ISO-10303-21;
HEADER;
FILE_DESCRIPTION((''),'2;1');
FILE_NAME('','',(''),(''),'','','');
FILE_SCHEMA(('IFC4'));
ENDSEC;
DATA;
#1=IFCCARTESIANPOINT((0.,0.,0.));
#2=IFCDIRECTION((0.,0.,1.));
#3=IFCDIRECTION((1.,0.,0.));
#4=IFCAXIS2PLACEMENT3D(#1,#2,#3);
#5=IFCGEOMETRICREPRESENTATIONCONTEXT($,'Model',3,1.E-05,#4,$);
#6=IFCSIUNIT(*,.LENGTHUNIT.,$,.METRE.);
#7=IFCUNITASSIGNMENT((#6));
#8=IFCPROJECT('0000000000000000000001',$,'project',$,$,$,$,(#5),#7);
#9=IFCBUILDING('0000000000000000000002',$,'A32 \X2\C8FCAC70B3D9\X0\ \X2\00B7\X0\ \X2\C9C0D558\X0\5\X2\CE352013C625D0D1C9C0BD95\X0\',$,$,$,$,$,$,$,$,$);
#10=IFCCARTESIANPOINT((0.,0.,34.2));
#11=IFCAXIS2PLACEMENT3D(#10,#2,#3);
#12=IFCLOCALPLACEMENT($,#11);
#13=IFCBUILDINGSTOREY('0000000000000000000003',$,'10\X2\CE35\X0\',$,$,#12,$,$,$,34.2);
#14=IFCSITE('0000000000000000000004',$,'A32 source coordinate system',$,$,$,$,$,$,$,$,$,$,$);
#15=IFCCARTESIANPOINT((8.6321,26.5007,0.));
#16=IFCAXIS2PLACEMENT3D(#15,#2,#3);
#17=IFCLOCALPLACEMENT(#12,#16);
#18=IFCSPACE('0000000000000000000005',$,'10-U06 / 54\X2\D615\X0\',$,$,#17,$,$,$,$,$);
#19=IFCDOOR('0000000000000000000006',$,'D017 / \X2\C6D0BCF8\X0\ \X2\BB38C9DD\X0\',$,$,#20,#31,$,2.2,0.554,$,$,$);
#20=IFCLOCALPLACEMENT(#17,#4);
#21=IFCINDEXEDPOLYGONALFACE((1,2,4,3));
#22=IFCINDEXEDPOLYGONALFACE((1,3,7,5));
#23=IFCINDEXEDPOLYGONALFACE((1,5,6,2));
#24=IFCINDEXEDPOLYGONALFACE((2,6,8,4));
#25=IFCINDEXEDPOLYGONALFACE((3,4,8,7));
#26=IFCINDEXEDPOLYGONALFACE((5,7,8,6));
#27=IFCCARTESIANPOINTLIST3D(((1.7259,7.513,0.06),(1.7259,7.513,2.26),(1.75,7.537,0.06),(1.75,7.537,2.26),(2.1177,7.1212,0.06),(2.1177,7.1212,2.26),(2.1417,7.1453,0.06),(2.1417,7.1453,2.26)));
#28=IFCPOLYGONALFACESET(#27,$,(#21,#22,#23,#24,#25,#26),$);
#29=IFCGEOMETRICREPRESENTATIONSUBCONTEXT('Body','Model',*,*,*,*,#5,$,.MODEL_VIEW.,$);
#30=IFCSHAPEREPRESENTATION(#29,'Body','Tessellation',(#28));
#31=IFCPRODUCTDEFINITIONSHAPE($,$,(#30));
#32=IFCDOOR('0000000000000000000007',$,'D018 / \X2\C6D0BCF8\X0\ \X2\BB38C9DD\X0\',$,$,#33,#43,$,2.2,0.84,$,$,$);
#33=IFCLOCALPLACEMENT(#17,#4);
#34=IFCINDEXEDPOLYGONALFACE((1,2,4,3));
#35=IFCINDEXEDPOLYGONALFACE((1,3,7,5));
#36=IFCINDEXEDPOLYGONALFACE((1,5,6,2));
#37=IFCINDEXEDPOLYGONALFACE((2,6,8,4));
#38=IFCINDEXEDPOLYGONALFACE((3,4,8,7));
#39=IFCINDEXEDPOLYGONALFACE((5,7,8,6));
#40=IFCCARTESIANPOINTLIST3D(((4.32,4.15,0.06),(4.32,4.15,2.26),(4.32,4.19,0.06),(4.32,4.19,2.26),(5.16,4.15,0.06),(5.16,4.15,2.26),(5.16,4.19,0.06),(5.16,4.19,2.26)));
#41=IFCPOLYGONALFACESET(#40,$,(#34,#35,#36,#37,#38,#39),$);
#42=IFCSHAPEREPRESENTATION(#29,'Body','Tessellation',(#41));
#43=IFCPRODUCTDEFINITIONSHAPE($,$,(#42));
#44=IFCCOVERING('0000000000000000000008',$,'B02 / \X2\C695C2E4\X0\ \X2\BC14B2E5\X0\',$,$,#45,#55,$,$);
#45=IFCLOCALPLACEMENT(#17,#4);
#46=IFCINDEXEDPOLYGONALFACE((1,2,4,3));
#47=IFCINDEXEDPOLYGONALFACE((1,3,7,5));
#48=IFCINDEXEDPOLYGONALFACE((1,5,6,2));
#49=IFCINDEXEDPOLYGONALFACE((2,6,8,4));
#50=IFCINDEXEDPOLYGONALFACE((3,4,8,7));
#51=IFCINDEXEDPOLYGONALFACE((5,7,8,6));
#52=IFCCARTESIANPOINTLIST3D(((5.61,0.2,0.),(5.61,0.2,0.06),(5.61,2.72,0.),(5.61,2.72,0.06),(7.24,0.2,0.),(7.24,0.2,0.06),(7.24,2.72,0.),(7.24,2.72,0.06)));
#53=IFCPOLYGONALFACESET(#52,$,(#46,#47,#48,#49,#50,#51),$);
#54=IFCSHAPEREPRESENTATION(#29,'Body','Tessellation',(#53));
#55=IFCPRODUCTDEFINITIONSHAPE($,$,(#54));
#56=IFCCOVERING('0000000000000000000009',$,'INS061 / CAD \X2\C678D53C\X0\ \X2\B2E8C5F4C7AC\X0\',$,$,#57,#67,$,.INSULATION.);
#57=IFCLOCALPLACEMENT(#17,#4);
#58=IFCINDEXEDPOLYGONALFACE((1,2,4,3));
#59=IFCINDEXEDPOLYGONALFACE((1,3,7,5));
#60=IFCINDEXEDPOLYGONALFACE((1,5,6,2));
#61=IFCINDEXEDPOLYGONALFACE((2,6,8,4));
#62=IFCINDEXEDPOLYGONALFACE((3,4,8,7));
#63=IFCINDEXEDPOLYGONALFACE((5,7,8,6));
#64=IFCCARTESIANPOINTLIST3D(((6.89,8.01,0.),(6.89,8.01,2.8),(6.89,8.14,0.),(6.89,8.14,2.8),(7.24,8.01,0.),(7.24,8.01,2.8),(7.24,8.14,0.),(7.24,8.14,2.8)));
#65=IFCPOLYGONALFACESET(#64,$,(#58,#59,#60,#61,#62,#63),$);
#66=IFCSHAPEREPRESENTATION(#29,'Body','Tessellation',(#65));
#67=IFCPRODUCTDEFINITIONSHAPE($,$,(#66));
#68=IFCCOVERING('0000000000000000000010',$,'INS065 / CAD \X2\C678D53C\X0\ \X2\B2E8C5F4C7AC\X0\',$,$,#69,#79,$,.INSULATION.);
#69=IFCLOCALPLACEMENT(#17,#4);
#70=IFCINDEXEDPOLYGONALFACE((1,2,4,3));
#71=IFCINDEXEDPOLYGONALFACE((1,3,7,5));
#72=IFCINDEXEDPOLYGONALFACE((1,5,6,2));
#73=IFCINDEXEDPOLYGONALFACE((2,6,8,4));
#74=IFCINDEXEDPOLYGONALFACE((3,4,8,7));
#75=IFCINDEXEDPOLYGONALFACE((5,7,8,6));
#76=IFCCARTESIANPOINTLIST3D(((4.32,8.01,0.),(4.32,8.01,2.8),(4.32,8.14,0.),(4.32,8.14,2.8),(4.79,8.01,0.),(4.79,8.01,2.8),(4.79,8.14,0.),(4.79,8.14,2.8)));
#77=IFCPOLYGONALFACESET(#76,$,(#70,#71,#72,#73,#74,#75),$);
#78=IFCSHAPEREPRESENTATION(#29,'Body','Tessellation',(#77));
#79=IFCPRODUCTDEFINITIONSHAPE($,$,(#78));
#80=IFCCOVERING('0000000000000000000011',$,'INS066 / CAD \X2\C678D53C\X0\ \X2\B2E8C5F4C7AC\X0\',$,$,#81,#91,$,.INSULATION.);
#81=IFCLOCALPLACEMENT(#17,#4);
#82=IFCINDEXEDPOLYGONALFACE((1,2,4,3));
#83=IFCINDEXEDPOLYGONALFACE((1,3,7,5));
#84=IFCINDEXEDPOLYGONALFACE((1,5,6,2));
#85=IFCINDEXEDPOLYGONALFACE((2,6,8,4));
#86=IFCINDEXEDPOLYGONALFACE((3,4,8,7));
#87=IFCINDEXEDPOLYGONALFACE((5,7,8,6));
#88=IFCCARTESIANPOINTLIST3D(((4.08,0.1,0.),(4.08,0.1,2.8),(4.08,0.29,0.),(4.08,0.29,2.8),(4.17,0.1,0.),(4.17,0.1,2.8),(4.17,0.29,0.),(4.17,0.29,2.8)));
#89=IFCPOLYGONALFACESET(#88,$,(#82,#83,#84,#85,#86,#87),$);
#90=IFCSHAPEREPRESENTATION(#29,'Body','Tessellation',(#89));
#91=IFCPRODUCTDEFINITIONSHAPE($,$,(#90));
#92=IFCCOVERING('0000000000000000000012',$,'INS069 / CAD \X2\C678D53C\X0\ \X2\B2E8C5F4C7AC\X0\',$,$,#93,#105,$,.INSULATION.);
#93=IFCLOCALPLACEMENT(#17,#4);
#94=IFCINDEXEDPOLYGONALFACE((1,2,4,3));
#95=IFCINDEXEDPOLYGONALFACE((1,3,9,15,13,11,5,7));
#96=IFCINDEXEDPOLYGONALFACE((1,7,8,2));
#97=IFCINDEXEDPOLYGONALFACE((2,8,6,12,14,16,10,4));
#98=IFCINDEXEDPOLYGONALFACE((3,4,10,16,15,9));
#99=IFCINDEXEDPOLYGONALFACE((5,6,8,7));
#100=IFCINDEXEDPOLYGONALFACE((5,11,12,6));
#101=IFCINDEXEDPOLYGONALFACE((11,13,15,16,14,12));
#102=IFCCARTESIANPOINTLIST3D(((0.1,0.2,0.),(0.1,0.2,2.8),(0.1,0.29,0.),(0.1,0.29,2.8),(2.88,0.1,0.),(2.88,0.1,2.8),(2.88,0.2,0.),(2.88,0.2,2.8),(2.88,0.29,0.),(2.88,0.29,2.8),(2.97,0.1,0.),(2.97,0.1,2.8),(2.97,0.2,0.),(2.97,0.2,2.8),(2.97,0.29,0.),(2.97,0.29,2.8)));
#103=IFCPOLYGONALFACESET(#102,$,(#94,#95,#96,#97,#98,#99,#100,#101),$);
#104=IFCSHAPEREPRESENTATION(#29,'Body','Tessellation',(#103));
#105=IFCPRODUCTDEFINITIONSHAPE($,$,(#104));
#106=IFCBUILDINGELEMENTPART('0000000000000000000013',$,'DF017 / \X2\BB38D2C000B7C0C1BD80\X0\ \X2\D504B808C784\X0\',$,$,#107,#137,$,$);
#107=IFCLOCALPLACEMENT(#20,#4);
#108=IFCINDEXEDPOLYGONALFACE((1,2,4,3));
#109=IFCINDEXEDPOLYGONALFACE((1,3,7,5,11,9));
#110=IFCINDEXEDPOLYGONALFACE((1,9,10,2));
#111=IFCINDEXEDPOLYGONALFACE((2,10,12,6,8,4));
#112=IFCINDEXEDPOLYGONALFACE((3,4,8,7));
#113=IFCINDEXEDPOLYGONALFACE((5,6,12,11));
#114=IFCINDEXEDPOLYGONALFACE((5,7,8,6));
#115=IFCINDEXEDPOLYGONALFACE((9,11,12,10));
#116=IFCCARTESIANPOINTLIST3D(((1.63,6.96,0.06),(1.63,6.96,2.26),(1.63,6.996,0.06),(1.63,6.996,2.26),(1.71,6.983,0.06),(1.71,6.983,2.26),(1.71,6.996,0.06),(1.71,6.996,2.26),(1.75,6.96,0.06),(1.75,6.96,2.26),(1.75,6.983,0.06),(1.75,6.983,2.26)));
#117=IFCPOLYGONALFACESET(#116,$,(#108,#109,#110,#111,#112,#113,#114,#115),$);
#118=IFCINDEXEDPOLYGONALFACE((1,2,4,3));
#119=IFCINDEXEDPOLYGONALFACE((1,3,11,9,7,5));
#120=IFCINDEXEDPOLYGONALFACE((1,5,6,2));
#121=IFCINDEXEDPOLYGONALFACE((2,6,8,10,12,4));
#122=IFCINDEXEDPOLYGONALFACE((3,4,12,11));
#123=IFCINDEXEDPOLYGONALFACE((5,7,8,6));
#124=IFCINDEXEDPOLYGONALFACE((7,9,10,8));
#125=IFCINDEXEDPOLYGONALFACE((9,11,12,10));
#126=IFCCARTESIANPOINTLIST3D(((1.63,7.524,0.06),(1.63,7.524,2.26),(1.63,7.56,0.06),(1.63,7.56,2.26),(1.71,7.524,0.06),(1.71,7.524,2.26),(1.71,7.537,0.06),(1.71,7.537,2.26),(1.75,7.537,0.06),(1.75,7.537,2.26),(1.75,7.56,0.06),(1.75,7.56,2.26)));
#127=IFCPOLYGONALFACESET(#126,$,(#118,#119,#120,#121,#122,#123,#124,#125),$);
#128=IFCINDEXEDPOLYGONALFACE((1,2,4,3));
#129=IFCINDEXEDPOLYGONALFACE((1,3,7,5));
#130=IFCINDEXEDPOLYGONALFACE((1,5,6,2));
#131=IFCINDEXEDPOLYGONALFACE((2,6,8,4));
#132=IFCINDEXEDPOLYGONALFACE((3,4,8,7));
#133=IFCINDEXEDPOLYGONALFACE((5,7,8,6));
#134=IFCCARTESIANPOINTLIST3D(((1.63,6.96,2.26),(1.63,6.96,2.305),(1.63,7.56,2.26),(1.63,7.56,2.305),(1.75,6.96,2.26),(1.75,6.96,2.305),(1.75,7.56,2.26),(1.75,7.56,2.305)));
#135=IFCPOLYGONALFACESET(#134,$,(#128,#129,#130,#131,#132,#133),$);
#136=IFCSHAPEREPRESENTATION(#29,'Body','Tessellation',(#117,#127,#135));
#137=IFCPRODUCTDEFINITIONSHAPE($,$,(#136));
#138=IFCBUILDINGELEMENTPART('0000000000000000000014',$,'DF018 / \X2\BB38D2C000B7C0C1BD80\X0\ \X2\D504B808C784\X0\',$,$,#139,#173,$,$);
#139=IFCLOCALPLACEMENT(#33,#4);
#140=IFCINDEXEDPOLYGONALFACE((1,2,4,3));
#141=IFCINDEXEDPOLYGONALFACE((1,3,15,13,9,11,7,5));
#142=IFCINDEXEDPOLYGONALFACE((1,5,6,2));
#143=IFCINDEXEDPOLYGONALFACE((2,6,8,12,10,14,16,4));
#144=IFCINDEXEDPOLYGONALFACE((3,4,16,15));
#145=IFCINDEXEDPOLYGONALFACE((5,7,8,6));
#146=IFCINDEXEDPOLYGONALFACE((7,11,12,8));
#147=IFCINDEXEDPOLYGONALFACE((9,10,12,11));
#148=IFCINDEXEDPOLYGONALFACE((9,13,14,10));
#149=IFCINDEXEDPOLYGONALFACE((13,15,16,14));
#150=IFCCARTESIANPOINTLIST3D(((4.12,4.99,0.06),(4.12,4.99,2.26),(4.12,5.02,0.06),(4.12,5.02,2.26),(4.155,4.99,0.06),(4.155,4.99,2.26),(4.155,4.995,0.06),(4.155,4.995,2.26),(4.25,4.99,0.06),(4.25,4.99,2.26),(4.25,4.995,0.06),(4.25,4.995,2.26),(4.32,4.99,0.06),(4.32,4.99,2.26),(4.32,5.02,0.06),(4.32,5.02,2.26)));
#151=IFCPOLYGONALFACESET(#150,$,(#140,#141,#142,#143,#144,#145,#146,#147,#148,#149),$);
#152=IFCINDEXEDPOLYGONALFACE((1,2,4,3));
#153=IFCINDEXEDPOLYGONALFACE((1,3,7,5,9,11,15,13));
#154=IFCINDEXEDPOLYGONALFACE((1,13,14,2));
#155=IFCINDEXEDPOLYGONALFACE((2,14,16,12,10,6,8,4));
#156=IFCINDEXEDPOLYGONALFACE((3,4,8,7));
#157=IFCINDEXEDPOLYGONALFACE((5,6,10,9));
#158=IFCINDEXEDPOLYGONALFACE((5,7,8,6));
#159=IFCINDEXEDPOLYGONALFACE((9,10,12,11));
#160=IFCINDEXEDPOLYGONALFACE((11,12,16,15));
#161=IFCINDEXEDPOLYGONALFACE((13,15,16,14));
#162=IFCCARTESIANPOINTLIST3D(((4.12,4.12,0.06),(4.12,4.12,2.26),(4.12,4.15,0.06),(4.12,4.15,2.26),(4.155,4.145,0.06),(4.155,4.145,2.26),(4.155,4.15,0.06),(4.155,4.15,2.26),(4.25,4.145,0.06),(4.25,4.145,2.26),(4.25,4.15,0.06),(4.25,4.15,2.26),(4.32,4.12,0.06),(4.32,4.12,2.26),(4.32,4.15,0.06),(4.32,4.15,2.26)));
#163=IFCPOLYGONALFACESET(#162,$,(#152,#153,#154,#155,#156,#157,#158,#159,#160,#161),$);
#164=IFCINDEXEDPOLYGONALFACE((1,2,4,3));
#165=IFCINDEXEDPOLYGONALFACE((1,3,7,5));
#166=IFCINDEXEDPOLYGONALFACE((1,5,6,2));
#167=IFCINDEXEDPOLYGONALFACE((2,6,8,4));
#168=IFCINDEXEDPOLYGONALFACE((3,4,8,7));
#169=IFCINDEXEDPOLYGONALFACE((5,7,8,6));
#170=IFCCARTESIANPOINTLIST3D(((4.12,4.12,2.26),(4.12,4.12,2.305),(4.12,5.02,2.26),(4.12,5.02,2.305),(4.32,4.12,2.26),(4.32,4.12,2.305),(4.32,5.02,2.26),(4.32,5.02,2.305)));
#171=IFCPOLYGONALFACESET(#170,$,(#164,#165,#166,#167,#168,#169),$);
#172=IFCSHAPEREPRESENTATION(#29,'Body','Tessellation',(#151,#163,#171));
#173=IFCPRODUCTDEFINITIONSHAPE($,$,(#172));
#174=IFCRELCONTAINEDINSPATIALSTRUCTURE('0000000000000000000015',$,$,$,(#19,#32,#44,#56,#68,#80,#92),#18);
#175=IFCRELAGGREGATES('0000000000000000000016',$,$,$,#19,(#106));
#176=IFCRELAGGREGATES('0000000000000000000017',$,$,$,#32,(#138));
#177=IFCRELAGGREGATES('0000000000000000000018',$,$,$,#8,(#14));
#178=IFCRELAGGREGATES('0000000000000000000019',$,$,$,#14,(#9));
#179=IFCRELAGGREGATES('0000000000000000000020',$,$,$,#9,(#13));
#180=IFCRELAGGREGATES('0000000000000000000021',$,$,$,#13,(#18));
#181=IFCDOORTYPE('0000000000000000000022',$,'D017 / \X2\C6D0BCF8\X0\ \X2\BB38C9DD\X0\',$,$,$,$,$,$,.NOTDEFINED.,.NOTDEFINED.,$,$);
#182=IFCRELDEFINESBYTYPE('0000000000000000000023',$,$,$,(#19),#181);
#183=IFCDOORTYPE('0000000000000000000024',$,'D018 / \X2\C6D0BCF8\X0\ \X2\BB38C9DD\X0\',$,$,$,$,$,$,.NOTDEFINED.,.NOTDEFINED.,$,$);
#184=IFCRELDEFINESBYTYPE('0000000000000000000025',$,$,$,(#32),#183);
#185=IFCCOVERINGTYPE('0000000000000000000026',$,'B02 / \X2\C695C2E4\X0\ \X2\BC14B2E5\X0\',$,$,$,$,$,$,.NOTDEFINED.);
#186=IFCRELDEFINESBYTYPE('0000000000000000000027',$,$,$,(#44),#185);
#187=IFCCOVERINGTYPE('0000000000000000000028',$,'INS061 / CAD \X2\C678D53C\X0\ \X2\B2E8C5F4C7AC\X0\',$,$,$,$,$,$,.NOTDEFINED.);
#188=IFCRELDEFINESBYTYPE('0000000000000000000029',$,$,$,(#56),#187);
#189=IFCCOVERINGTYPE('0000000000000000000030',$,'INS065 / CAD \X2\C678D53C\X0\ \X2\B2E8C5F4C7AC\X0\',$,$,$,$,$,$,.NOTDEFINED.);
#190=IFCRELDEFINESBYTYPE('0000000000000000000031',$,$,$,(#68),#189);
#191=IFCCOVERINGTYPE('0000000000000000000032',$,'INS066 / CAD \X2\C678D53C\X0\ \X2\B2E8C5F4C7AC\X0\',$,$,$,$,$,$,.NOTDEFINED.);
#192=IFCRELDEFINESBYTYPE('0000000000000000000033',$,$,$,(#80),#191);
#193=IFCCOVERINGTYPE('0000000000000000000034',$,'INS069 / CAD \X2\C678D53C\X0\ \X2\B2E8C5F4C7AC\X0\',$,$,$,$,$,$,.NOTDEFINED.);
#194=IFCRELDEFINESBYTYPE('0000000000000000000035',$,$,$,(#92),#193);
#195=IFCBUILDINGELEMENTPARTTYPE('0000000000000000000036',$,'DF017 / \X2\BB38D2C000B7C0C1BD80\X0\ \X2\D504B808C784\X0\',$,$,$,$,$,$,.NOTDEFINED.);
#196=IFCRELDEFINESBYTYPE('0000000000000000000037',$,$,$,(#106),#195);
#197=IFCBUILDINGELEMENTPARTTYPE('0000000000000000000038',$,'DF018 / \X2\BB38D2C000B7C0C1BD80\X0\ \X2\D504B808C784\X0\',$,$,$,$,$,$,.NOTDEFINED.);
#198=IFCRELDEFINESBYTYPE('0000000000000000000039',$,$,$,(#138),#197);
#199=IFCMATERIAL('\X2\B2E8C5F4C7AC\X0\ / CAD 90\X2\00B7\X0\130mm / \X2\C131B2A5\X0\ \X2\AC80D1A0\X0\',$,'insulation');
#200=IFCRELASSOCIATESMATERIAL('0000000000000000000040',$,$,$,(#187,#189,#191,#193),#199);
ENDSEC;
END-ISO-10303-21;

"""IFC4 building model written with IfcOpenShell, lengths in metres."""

from ifc_helpers import new_model, si_unit, frame, origin, origin_with_axes, place, context, subcontext, project, spatial, polyline, outline, extrude, source, transform, mapped, material, type_object, type_shapes, element, aggregate, save


model = new_model("IFC4")

# Units and contexts
model_context = context("Model", 3, precision=1e-05, world=origin_with_axes())
body_context = subcontext(model_context, "Body", "Model", "MODEL_VIEW")
ifc_project = project(units=[si_unit("LENGTHUNIT", "METRE")], contexts=[model_context])

# Site, building, storey, space
storey_placement = place(None, frame((0.0, 0.0, 34.2), z_axis=(0.0, 0.0, 1.0), x_axis=(1.0, 0.0, 0.0)))
space_1_placement = place(storey_placement, frame((8.6321, 26.5007, 0.0), z_axis=(0.0, 0.0, 1.0), x_axis=(1.0, 0.0, 0.0)))
site = spatial("IfcSite", under=ifc_project, Name="A32 source coordinate system")
building = spatial("IfcBuilding", under=site, Name="A32 주거동 · 지하5층–옥탑지붕")
storey = spatial("IfcBuildingStorey", under=building, at=storey_placement, Name="10층", Elevation=34.2)
space_1 = spatial("IfcSpace", under=storey, at=space_1_placement, Name="10-U06 / 54형")

# Doors
door_type_1 = type_object("IfcDoorType", Name="D017 / 원본 문짝", OperationType="NOTDEFINED", PredefinedType="NOTDEFINED")
shared_shape_1 = source(origin(), body_context, "Body", "SweptSolid", [
    extrude(outline(polyline([(1.75, 7.537), (2.1417, 7.1453), (2.1177, 7.1212), (1.7259, 7.513), (1.75, 7.537)])), frame((0.0, 0.0, 0.06)), (0.0, 0.0, 1.0), 2.2),
])
type_shapes(door_type_1, [shared_shape_1])
door_1_placement = place(space_1_placement, origin_with_axes())
door_1 = element("IfcDoor", 1, at=door_1_placement, inside=space_1, type_object=door_type_1, Name="D017 / 원본 문짝", OverallHeight=2.2, OverallWidth=0.554, context=body_context, shape_type="MappedRepresentation", body=[
    mapped(shared_shape_1, transform((0.0, 0.0, 0.0), scale=1.0)),
])
door_type_2 = type_object("IfcDoorType", Name="D018 / 원본 문짝", OperationType="NOTDEFINED", PredefinedType="NOTDEFINED")
shared_shape_2 = source(origin(), body_context, "Body", "SweptSolid", [
    extrude(outline(polyline([(5.16, 4.19), (5.16, 4.15), (4.32, 4.15), (4.32, 4.19), (5.16, 4.19)])), frame((0.0, 0.0, 0.06)), (0.0, 0.0, 1.0), 2.2),
])
type_shapes(door_type_2, [shared_shape_2])
door_2_placement = place(space_1_placement, origin_with_axes())
door_2 = element("IfcDoor", 2, at=door_2_placement, inside=space_1, type_object=door_type_2, Name="D018 / 원본 문짝", OverallHeight=2.2, OverallWidth=0.84, context=body_context, shape_type="MappedRepresentation", body=[
    mapped(shared_shape_2, transform((0.0, 0.0, 0.0), scale=1.0)),
])

# Coverings
covering_type_1 = type_object("IfcCoveringType", Name="B02 / 욕실 바닥", PredefinedType="NOTDEFINED")
shared_shape_3 = source(origin(), body_context, "Body", "SweptSolid", [
    extrude(outline(polyline([(5.61, 2.72), (7.24, 2.72), (7.24, 0.2), (5.61, 0.2), (5.61, 2.72)])), origin(), (0.0, 0.0, 1.0), 0.06),
])
type_shapes(covering_type_1, [shared_shape_3])
covering_1_placement = place(space_1_placement, origin_with_axes())
element("IfcCovering", 3, at=covering_1_placement, inside=space_1, type_object=covering_type_1, Name="B02 / 욕실 바닥", context=body_context, shape_type="MappedRepresentation", body=[
    mapped(shared_shape_3, transform((0.0, 0.0, 0.0), scale=1.0)),
])
ifc_material = material(Name="단열재 / CAD 90·130mm / 성능 검토", Category="insulation")
covering_type_2 = type_object("IfcCoveringType", Name="INS061 / CAD 외피 단열재", PredefinedType="NOTDEFINED", material=ifc_material)
shared_shape_4 = source(origin(), body_context, "Body", "SweptSolid", [
    extrude(outline(polyline([(6.89, 8.01), (6.89, 8.14), (7.24, 8.14), (7.24, 8.01), (6.89, 8.01)])), origin(), (0.0, 0.0, 1.0), 2.8),
])
type_shapes(covering_type_2, [shared_shape_4])
covering_2_placement = place(space_1_placement, origin_with_axes())
element("IfcCovering", 4, at=covering_2_placement, inside=space_1, type_object=covering_type_2, Name="INS061 / CAD 외피 단열재", PredefinedType="INSULATION", context=body_context, shape_type="MappedRepresentation", body=[
    mapped(shared_shape_4, transform((0.0, 0.0, 0.0), scale=1.0)),
])
covering_type_3 = type_object("IfcCoveringType", Name="INS065 / CAD 외피 단열재", PredefinedType="NOTDEFINED", material=ifc_material)
shared_shape_5 = source(origin(), body_context, "Body", "SweptSolid", [
    extrude(outline(polyline([(4.32, 8.01), (4.32, 8.14), (4.79, 8.14), (4.79, 8.01), (4.32, 8.01)])), origin(), (0.0, 0.0, 1.0), 2.8),
])
type_shapes(covering_type_3, [shared_shape_5])
covering_3_placement = place(space_1_placement, origin_with_axes())
element("IfcCovering", 5, at=covering_3_placement, inside=space_1, type_object=covering_type_3, Name="INS065 / CAD 외피 단열재", PredefinedType="INSULATION", context=body_context, shape_type="MappedRepresentation", body=[
    mapped(shared_shape_5, transform((0.0, 0.0, 0.0), scale=1.0)),
])
covering_type_4 = type_object("IfcCoveringType", Name="INS066 / CAD 외피 단열재", PredefinedType="NOTDEFINED", material=ifc_material)
shared_shape_6 = source(origin(), body_context, "Body", "SweptSolid", [
    extrude(outline(polyline([(4.08, 0.29), (4.17, 0.29), (4.17, 0.1), (4.08, 0.1), (4.08, 0.29)])), origin(), (0.0, 0.0, 1.0), 2.8),
])
type_shapes(covering_type_4, [shared_shape_6])
covering_4_placement = place(space_1_placement, origin_with_axes())
element("IfcCovering", 6, at=covering_4_placement, inside=space_1, type_object=covering_type_4, Name="INS066 / CAD 외피 단열재", PredefinedType="INSULATION", context=body_context, shape_type="MappedRepresentation", body=[
    mapped(shared_shape_6, transform((0.0, 0.0, 0.0), scale=1.0)),
])
covering_type_5 = type_object("IfcCoveringType", Name="INS069 / CAD 외피 단열재", PredefinedType="NOTDEFINED", material=ifc_material)
shared_shape_7 = source(origin(), body_context, "Body", "SweptSolid", [
    extrude(outline(polyline([(2.97, 0.1), (2.88, 0.1), (2.88, 0.2), (0.1, 0.2), (0.1, 0.29), (2.88, 0.29), (2.97, 0.29), (2.97, 0.2), (2.97, 0.1)])), origin(), (0.0, 0.0, 1.0), 2.8),
])
type_shapes(covering_type_5, [shared_shape_7])
covering_5_placement = place(space_1_placement, origin_with_axes())
element("IfcCovering", 7, at=covering_5_placement, inside=space_1, type_object=covering_type_5, Name="INS069 / CAD 외피 단열재", PredefinedType="INSULATION", context=body_context, shape_type="MappedRepresentation", body=[
    mapped(shared_shape_7, transform((0.0, 0.0, 0.0), scale=1.0)),
])

# Building element parts
building_element_part_type_1 = type_object("IfcBuildingElementPartType", Name="DF017 / 문틀·상부 프레임", PredefinedType="NOTDEFINED")
shared_shape_8 = source(origin(), body_context, "Body", "SweptSolid", [
    extrude(outline(polyline([(1.63, 6.996), (1.71, 6.996), (1.71, 6.983), (1.75, 6.983), (1.75, 6.96), (1.63, 6.96), (1.63, 6.996)])), frame((0.0, 0.0, 0.06)), (0.0, 0.0, 1.0), 2.2),
    extrude(outline(polyline([(1.75, 7.56), (1.75, 7.537), (1.71, 7.537), (1.71, 7.524), (1.63, 7.524), (1.63, 7.56), (1.75, 7.56)])), frame((0.0, 0.0, 0.06)), (0.0, 0.0, 1.0), 2.2),
    extrude(outline(polyline([(1.63, 6.96), (1.63, 7.56), (1.75, 7.56), (1.75, 6.96), (1.63, 6.96)])), frame((0.0, 0.0, 2.26)), (0.0, 0.0, 1.0), 0.045),
])
type_shapes(building_element_part_type_1, [shared_shape_8])
building_element_part_1_placement = place(door_1_placement, origin_with_axes())
building_element_part_1 = element("IfcBuildingElementPart", 8, at=building_element_part_1_placement, type_object=building_element_part_type_1, Name="DF017 / 문틀·상부 프레임", context=body_context, shape_type="MappedRepresentation", body=[
    mapped(shared_shape_8, transform((0.0, 0.0, 0.0), scale=1.0)),
])
aggregate(door_1, [building_element_part_1])
building_element_part_type_2 = type_object("IfcBuildingElementPartType", Name="DF018 / 문틀·상부 프레임", PredefinedType="NOTDEFINED")
shared_shape_9 = source(origin(), body_context, "Body", "SweptSolid", [
    extrude(outline(polyline([(4.32, 4.99), (4.25, 4.99), (4.25, 4.995), (4.155, 4.995), (4.155, 4.99), (4.12, 4.99), (4.12, 5.02), (4.32, 5.02), (4.32, 4.99)])), frame((0.0, 0.0, 0.06)), (0.0, 0.0, 1.0), 2.2),
    extrude(outline(polyline([(4.12, 4.12), (4.12, 4.15), (4.155, 4.15), (4.155, 4.145), (4.25, 4.145), (4.25, 4.15), (4.32, 4.15), (4.32, 4.12), (4.12, 4.12)])), frame((0.0, 0.0, 0.06)), (0.0, 0.0, 1.0), 2.2),
    extrude(outline(polyline([(4.12, 4.12), (4.12, 5.02), (4.32, 5.02), (4.32, 4.12), (4.12, 4.12)])), frame((0.0, 0.0, 2.26)), (0.0, 0.0, 1.0), 0.045),
])
type_shapes(building_element_part_type_2, [shared_shape_9])
building_element_part_2_placement = place(door_2_placement, origin_with_axes())
building_element_part_2 = element("IfcBuildingElementPart", 9, at=building_element_part_2_placement, type_object=building_element_part_type_2, Name="DF018 / 문틀·상부 프레임", context=body_context, shape_type="MappedRepresentation", body=[
    mapped(shared_shape_9, transform((0.0, 0.0, 0.0), scale=1.0)),
])
aggregate(door_2, [building_element_part_2])

save(model, "model.ifc")
